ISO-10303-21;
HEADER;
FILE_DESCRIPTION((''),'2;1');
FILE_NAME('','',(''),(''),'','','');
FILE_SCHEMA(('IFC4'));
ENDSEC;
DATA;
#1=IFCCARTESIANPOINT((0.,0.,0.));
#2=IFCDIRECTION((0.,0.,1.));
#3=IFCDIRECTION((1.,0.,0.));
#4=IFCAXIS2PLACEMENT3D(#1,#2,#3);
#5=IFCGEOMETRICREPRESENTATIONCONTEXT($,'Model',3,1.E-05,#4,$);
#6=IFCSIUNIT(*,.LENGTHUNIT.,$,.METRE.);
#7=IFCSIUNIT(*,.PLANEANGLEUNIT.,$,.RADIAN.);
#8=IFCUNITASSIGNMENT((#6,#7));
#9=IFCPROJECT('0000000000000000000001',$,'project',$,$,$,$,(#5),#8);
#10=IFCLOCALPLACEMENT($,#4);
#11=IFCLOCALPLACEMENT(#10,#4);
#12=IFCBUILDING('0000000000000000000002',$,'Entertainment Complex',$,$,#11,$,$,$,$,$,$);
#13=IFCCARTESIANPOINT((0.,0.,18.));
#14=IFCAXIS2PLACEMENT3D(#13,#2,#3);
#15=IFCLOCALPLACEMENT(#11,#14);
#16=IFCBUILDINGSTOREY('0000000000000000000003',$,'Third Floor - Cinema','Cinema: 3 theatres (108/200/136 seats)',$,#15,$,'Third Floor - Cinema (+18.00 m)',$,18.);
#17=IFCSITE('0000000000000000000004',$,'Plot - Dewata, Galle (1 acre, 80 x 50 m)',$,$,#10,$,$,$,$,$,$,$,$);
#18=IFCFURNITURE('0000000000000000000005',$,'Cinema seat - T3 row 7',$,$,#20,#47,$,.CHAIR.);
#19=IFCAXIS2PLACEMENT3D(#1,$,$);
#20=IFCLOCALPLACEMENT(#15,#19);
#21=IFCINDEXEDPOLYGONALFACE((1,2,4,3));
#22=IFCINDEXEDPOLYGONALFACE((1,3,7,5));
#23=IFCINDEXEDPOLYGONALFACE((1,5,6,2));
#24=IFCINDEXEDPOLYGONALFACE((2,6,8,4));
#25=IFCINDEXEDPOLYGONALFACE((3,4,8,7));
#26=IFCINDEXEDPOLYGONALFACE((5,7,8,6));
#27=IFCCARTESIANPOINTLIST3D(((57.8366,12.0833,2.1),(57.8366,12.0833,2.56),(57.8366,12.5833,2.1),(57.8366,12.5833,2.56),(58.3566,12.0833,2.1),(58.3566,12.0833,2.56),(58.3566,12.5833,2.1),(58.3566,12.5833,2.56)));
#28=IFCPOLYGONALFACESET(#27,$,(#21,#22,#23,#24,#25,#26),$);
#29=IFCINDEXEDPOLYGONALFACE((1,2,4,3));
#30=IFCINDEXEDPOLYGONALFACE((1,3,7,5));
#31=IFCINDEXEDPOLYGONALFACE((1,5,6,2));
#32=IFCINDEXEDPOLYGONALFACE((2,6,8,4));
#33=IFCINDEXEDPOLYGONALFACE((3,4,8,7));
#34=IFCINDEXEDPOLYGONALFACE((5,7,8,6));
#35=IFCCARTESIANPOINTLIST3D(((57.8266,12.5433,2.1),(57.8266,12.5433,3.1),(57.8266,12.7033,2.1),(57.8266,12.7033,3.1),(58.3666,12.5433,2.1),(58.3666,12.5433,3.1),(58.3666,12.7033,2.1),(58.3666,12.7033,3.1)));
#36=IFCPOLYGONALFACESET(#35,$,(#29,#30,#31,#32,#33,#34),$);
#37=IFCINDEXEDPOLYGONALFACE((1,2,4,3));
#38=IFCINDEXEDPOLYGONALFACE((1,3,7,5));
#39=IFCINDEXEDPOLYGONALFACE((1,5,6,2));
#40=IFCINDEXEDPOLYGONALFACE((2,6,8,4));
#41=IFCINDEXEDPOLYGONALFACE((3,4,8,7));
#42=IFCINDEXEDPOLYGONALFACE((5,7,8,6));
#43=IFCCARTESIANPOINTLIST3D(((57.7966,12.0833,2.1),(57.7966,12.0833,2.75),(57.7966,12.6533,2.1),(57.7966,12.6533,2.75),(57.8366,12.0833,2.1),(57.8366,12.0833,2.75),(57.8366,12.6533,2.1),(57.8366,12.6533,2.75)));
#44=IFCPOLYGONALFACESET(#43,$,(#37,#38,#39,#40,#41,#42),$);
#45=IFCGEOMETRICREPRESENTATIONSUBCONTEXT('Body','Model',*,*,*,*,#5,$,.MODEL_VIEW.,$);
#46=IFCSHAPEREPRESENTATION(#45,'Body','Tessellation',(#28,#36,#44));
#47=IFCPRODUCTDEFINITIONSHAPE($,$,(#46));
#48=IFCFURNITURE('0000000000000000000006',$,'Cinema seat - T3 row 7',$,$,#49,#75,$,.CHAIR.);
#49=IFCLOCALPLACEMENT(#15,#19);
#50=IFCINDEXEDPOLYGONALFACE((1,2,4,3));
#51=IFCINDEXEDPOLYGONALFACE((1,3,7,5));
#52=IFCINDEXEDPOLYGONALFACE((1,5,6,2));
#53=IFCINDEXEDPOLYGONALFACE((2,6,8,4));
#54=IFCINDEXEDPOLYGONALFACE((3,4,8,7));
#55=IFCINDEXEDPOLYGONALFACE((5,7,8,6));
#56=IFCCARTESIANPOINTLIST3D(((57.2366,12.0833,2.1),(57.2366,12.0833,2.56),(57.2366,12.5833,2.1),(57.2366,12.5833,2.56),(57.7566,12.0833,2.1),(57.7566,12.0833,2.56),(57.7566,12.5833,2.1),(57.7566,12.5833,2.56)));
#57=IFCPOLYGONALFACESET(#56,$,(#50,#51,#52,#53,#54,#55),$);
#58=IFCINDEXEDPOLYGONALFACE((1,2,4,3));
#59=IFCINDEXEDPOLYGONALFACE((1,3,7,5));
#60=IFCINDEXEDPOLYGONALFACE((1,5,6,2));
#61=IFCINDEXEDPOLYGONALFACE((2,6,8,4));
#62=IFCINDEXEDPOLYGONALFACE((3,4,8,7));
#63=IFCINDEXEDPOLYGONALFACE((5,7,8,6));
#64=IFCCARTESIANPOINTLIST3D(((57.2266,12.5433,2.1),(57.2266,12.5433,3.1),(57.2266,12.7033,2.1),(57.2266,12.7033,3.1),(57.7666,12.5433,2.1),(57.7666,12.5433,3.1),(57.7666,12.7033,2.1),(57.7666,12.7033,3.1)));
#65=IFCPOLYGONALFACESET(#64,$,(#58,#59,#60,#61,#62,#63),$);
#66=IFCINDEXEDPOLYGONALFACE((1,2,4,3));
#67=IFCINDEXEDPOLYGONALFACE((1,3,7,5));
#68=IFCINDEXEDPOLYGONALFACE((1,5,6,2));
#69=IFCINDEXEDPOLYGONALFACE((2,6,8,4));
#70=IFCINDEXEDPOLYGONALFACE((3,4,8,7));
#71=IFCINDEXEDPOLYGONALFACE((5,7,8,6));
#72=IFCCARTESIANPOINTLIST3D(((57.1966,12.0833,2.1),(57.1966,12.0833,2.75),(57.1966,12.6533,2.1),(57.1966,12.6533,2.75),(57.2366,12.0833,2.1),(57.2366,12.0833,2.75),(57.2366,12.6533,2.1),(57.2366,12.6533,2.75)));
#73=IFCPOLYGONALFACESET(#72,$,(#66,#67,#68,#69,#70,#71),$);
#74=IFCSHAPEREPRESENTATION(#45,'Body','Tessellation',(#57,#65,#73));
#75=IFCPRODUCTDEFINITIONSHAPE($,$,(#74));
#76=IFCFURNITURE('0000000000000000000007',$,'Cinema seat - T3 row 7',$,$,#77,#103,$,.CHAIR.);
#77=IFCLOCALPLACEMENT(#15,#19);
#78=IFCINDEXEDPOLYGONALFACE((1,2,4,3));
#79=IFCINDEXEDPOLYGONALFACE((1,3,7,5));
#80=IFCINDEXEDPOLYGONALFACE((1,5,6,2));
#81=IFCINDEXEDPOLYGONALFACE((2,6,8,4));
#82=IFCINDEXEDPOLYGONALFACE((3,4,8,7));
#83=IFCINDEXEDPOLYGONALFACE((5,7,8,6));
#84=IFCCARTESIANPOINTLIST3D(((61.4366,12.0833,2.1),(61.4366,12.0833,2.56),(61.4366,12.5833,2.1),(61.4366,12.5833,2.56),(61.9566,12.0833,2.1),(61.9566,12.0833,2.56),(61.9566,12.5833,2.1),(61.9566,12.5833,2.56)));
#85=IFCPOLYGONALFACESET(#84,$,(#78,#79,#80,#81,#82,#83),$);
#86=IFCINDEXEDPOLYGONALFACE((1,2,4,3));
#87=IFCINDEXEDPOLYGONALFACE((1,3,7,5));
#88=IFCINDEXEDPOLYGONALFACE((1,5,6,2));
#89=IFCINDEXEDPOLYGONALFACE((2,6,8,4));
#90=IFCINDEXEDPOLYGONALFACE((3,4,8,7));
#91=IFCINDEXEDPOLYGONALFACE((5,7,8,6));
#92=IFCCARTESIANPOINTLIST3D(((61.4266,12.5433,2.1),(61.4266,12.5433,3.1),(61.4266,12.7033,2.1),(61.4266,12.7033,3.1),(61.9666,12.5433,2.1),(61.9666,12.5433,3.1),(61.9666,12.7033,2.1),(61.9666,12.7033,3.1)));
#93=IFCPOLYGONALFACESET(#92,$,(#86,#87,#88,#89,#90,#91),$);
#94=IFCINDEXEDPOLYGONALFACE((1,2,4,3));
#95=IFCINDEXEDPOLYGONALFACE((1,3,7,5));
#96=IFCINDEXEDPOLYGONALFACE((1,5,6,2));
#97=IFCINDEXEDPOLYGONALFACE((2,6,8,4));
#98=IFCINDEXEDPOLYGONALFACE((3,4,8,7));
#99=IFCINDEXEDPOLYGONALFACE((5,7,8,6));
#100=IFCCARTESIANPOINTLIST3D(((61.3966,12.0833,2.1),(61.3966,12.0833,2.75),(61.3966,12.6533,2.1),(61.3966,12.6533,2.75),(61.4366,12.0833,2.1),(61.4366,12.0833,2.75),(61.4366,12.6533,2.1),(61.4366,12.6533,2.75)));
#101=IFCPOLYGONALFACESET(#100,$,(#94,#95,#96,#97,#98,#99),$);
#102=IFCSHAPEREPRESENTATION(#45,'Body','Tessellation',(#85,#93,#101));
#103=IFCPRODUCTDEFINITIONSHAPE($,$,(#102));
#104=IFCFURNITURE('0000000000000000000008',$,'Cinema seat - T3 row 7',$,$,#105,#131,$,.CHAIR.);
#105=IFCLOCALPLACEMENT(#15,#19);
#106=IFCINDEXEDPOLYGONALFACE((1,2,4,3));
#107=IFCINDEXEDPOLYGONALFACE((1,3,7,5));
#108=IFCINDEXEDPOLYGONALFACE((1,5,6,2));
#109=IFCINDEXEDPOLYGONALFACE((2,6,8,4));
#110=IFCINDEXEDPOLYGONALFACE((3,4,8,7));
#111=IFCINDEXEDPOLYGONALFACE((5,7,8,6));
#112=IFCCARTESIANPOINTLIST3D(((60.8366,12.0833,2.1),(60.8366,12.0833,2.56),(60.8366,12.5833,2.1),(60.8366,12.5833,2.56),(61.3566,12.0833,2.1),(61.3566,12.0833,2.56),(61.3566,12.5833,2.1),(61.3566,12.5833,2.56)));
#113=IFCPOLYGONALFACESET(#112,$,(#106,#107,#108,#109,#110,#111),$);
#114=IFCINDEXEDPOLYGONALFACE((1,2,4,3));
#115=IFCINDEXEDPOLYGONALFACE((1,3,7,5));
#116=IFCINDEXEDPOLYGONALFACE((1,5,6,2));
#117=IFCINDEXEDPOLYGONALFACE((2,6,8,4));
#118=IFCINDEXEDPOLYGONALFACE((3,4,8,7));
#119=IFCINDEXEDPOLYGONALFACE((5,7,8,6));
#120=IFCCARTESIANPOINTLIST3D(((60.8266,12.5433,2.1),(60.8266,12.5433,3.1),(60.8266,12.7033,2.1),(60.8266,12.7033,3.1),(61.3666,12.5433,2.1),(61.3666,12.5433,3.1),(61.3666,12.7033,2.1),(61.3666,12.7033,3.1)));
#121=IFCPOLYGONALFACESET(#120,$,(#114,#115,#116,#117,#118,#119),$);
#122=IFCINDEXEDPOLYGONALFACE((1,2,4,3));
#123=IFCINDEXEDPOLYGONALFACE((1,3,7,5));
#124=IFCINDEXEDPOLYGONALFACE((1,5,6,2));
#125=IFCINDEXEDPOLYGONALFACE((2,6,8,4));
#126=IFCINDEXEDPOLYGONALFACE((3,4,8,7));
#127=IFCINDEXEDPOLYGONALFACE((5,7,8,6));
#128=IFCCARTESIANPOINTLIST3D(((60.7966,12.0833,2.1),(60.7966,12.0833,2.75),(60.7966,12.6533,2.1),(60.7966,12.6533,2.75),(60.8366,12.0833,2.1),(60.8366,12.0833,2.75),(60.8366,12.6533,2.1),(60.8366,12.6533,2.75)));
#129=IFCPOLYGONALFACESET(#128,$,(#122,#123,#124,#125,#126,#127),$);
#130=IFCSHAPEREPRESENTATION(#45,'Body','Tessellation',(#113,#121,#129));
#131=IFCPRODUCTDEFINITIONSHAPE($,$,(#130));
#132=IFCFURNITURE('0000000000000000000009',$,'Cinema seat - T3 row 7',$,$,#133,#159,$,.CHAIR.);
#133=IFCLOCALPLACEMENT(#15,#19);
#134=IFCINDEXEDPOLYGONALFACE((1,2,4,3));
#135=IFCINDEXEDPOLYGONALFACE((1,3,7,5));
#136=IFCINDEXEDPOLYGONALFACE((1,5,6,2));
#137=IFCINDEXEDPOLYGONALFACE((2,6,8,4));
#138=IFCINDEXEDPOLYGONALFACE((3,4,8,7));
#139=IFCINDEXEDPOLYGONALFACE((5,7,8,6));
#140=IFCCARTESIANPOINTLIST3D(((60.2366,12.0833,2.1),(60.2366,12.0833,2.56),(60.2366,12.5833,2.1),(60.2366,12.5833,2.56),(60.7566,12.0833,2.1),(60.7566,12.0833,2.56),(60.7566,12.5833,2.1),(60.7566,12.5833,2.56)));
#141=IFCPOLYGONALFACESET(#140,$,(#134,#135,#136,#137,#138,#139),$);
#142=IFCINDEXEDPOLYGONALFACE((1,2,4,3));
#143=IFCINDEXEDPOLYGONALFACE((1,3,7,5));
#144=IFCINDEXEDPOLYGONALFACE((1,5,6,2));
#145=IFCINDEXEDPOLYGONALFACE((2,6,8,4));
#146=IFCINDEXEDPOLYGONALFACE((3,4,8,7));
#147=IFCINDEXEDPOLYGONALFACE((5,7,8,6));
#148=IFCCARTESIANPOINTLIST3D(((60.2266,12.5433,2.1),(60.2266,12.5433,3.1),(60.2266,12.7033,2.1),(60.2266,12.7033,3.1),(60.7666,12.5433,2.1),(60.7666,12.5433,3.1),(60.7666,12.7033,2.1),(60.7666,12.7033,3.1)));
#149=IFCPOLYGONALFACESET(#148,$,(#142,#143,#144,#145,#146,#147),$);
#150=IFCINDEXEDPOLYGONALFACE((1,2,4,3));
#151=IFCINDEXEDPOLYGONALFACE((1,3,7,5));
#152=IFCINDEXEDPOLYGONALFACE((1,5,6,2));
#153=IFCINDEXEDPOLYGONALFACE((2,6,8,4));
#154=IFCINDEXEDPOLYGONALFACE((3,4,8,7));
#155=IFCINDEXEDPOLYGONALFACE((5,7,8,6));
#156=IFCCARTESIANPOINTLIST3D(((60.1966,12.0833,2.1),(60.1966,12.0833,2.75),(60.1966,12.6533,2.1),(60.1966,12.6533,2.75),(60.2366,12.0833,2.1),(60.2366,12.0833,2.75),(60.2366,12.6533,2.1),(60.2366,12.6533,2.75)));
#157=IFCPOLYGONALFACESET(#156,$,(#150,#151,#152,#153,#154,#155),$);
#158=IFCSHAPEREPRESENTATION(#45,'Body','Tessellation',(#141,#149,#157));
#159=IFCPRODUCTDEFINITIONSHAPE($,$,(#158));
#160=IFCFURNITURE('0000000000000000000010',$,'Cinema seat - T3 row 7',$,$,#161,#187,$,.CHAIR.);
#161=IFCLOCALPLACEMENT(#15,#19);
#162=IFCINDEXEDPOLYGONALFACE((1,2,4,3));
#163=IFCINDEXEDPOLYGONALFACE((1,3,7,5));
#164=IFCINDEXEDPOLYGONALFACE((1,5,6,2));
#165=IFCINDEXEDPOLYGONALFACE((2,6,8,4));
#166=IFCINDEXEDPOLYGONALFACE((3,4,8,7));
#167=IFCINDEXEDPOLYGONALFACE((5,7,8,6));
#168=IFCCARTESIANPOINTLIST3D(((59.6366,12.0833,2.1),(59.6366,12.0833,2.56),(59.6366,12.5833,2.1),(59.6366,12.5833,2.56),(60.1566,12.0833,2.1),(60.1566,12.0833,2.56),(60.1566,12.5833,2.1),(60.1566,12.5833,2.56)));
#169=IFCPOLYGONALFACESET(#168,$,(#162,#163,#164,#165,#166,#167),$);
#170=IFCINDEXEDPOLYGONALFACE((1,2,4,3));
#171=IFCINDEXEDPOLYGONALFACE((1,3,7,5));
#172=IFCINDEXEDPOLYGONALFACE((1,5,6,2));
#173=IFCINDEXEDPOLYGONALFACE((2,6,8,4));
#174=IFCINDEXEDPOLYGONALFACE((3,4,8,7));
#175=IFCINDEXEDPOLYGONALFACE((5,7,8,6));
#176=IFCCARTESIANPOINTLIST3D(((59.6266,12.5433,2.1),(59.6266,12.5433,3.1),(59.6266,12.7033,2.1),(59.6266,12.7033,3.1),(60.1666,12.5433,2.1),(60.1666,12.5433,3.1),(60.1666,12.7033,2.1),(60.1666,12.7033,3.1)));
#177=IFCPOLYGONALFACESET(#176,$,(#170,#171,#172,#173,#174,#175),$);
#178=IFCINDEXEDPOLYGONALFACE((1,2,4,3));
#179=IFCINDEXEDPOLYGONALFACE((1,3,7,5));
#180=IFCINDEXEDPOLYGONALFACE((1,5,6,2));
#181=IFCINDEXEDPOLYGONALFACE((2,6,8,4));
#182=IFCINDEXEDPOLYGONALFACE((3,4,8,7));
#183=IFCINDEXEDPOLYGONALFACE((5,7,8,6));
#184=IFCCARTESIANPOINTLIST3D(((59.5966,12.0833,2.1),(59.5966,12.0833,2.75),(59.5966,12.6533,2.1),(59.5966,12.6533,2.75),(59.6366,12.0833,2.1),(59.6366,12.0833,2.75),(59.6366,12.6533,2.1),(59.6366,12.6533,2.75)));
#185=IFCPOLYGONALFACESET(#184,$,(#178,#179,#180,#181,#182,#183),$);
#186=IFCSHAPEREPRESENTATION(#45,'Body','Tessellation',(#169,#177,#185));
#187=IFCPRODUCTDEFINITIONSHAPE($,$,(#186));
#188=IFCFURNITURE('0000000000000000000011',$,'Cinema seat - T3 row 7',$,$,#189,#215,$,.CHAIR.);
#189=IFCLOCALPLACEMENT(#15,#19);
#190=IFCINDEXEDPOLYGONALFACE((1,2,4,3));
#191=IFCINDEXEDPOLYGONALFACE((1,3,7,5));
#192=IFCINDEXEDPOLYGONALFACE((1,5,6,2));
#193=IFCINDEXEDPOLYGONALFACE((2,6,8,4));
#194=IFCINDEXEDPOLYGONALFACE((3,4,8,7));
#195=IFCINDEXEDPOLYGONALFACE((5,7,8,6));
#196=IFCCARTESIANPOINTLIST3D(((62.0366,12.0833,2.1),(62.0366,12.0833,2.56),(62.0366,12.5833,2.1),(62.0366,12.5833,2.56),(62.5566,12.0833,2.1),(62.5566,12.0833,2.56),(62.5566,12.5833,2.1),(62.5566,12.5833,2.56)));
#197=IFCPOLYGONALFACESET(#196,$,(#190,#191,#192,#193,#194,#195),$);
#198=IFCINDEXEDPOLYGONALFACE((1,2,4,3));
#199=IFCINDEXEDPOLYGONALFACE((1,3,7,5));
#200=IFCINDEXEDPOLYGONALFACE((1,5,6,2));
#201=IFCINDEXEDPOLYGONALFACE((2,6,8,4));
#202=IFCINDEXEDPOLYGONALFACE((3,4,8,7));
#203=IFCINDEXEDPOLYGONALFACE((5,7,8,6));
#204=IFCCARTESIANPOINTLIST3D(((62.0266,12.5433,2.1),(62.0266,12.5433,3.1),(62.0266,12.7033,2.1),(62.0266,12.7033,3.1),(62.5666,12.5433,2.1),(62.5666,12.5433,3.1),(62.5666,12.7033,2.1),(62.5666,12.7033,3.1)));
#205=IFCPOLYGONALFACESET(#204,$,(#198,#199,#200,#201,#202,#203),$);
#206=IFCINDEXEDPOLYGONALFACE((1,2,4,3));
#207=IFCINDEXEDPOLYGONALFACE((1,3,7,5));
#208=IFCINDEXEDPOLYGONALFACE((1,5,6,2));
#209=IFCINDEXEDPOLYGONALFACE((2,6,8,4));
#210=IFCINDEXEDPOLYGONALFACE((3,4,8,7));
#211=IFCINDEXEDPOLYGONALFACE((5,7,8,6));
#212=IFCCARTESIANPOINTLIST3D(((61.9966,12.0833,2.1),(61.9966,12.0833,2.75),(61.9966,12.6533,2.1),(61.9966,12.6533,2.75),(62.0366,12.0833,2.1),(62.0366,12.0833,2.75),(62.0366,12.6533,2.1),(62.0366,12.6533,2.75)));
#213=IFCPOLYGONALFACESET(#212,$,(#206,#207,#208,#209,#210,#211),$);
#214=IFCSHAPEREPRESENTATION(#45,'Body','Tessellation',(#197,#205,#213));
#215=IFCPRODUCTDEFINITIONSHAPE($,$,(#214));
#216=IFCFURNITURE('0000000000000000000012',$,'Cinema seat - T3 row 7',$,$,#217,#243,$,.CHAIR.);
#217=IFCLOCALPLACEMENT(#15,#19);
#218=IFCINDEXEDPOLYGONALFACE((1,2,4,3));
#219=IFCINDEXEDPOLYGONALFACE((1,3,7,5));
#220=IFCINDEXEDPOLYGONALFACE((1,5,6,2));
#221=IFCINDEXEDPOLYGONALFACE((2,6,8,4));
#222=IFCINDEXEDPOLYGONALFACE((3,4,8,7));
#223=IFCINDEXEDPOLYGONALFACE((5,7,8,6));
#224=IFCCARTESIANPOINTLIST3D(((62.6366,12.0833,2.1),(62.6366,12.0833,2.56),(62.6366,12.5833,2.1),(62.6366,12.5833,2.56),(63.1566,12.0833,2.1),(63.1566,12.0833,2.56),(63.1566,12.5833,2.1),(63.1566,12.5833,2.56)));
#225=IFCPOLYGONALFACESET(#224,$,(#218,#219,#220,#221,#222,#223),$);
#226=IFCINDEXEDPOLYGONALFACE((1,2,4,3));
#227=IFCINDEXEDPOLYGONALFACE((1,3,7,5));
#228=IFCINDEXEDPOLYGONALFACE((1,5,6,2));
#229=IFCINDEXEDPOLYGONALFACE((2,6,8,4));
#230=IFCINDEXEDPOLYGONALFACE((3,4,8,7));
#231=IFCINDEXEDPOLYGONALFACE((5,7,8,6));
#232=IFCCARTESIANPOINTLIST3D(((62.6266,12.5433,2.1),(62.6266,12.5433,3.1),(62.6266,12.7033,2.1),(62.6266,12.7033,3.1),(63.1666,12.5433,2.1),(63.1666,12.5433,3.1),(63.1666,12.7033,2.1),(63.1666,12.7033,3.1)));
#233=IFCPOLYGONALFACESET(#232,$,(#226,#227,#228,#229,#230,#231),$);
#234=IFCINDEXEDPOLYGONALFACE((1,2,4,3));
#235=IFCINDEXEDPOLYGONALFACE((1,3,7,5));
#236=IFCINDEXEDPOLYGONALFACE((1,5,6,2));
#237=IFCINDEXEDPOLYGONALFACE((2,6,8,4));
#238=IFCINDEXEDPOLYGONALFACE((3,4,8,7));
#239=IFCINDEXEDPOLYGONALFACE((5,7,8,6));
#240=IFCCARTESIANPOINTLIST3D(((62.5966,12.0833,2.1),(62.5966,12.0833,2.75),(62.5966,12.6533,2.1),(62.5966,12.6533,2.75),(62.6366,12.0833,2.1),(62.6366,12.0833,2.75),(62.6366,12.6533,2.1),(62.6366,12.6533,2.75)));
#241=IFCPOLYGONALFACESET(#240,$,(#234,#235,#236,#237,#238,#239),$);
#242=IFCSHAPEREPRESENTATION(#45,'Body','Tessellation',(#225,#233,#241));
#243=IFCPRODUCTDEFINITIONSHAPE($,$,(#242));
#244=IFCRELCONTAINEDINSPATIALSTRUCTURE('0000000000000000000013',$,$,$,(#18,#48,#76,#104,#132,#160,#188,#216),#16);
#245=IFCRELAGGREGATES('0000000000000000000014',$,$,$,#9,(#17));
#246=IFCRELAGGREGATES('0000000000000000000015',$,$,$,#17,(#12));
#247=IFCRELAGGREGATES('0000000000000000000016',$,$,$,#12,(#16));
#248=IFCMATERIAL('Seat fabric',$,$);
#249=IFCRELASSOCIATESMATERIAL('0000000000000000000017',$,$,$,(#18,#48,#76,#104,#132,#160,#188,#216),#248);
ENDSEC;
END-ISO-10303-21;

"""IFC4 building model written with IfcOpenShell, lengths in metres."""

from ifc_helpers import new_model, si_unit, frame, origin_with_axes, place, context, subcontext, project, spatial, polyline, outline, extrude, material, element, save


model = new_model("IFC4")

# Units and contexts
model_context = context("Model", 3, precision=1e-05, world=origin_with_axes())
body_context = subcontext(model_context, "Body", "Model", "MODEL_VIEW")
ifc_project = project(units=[si_unit("LENGTHUNIT", "METRE"), si_unit("PLANEANGLEUNIT", "RADIAN")], contexts=[model_context])

# Site, building, storey
site_placement = place(None, origin_with_axes())
site = spatial("IfcSite", under=ifc_project, at=site_placement, Name="Plot - Dewata, Galle (1 acre, 80 x 50 m)")
building_placement = place(site_placement, origin_with_axes())
building = spatial("IfcBuilding", under=site, at=building_placement, Name="Entertainment Complex")
storey_placement = place(building_placement, frame((0.0, 0.0, 18.0), z_axis=(0.0, 0.0, 1.0), x_axis=(1.0, 0.0, 0.0)))
storey = spatial("IfcBuildingStorey", under=building, at=storey_placement, Name="Third Floor - Cinema", Description="Cinema: 3 theatres (108/200/136 seats)", LongName="Third Floor - Cinema (+18.00 m)", Elevation=18.0)

# Furniture
ifc_material_1 = material(Name="Seat fabric")
for number, where, z_axis, x_axis, name in (
    (1, (58.0966, 12.7033, 2.1), (0.0, 0.0, 1.0), (0.0, 1.0, 0.0), "Cinema seat - T3 row 7"),
    (2, (57.4966, 12.7033, 2.1), (0.0, 0.0, 1.0), (0.0, 1.0, 0.0), "Cinema seat - T3 row 7"),
    (3, (61.6966, 12.7033, 2.1), (0.0, 0.0, 1.0), (0.0, 1.0, 0.0), "Cinema seat - T3 row 7"),
    (4, (61.0966, 12.7033, 2.1), (0.0, 0.0, 1.0), (0.0, 1.0, 0.0), "Cinema seat - T3 row 7"),
    (5, (60.4966, 12.7033, 2.1), (0.0, 0.0, 1.0), (0.0, 1.0, 0.0), "Cinema seat - T3 row 7"),
    (6, (59.8966, 12.7033, 2.1), (0.0, 0.0, 1.0), (0.0, 1.0, 0.0), "Cinema seat - T3 row 7"),
    (7, (62.2966, 12.7033, 2.1), (0.0, 0.0, 1.0), (0.0, 1.0, 0.0), "Cinema seat - T3 row 7"),
    (8, (62.8966, 12.7033, 2.1), (0.0, 0.0, 1.0), (0.0, 1.0, 0.0), "Cinema seat - T3 row 7"),
):
    element("IfcFurniture", number, at=place(storey_placement, frame(where, z_axis=z_axis, x_axis=x_axis)), inside=storey, material=ifc_material_1, Name=name, PredefinedType="CHAIR", context=body_context, shape_type="SweptSolid", body=[
        extrude(outline(polyline([(-0.62, -0.26), (-0.12, -0.26), (-0.12, 0.26), (-0.62, 0.26), (-0.62, -0.26)])), origin_with_axes(), (0.0, 0.0, 1.0), 0.46),
        extrude(outline(polyline([(-0.16, -0.27), (0.0, -0.27), (0.0, 0.27), (-0.16, 0.27), (-0.16, -0.27)])), origin_with_axes(), (0.0, 0.0, 1.0), 1.0),
        extrude(outline(polyline([(-0.62, 0.26), (-0.05, 0.26), (-0.05, 0.3), (-0.62, 0.3), (-0.62, 0.26)])), origin_with_axes(), (0.0, 0.0, 1.0), 0.65),
    ])

save(model, "model.ifc")
